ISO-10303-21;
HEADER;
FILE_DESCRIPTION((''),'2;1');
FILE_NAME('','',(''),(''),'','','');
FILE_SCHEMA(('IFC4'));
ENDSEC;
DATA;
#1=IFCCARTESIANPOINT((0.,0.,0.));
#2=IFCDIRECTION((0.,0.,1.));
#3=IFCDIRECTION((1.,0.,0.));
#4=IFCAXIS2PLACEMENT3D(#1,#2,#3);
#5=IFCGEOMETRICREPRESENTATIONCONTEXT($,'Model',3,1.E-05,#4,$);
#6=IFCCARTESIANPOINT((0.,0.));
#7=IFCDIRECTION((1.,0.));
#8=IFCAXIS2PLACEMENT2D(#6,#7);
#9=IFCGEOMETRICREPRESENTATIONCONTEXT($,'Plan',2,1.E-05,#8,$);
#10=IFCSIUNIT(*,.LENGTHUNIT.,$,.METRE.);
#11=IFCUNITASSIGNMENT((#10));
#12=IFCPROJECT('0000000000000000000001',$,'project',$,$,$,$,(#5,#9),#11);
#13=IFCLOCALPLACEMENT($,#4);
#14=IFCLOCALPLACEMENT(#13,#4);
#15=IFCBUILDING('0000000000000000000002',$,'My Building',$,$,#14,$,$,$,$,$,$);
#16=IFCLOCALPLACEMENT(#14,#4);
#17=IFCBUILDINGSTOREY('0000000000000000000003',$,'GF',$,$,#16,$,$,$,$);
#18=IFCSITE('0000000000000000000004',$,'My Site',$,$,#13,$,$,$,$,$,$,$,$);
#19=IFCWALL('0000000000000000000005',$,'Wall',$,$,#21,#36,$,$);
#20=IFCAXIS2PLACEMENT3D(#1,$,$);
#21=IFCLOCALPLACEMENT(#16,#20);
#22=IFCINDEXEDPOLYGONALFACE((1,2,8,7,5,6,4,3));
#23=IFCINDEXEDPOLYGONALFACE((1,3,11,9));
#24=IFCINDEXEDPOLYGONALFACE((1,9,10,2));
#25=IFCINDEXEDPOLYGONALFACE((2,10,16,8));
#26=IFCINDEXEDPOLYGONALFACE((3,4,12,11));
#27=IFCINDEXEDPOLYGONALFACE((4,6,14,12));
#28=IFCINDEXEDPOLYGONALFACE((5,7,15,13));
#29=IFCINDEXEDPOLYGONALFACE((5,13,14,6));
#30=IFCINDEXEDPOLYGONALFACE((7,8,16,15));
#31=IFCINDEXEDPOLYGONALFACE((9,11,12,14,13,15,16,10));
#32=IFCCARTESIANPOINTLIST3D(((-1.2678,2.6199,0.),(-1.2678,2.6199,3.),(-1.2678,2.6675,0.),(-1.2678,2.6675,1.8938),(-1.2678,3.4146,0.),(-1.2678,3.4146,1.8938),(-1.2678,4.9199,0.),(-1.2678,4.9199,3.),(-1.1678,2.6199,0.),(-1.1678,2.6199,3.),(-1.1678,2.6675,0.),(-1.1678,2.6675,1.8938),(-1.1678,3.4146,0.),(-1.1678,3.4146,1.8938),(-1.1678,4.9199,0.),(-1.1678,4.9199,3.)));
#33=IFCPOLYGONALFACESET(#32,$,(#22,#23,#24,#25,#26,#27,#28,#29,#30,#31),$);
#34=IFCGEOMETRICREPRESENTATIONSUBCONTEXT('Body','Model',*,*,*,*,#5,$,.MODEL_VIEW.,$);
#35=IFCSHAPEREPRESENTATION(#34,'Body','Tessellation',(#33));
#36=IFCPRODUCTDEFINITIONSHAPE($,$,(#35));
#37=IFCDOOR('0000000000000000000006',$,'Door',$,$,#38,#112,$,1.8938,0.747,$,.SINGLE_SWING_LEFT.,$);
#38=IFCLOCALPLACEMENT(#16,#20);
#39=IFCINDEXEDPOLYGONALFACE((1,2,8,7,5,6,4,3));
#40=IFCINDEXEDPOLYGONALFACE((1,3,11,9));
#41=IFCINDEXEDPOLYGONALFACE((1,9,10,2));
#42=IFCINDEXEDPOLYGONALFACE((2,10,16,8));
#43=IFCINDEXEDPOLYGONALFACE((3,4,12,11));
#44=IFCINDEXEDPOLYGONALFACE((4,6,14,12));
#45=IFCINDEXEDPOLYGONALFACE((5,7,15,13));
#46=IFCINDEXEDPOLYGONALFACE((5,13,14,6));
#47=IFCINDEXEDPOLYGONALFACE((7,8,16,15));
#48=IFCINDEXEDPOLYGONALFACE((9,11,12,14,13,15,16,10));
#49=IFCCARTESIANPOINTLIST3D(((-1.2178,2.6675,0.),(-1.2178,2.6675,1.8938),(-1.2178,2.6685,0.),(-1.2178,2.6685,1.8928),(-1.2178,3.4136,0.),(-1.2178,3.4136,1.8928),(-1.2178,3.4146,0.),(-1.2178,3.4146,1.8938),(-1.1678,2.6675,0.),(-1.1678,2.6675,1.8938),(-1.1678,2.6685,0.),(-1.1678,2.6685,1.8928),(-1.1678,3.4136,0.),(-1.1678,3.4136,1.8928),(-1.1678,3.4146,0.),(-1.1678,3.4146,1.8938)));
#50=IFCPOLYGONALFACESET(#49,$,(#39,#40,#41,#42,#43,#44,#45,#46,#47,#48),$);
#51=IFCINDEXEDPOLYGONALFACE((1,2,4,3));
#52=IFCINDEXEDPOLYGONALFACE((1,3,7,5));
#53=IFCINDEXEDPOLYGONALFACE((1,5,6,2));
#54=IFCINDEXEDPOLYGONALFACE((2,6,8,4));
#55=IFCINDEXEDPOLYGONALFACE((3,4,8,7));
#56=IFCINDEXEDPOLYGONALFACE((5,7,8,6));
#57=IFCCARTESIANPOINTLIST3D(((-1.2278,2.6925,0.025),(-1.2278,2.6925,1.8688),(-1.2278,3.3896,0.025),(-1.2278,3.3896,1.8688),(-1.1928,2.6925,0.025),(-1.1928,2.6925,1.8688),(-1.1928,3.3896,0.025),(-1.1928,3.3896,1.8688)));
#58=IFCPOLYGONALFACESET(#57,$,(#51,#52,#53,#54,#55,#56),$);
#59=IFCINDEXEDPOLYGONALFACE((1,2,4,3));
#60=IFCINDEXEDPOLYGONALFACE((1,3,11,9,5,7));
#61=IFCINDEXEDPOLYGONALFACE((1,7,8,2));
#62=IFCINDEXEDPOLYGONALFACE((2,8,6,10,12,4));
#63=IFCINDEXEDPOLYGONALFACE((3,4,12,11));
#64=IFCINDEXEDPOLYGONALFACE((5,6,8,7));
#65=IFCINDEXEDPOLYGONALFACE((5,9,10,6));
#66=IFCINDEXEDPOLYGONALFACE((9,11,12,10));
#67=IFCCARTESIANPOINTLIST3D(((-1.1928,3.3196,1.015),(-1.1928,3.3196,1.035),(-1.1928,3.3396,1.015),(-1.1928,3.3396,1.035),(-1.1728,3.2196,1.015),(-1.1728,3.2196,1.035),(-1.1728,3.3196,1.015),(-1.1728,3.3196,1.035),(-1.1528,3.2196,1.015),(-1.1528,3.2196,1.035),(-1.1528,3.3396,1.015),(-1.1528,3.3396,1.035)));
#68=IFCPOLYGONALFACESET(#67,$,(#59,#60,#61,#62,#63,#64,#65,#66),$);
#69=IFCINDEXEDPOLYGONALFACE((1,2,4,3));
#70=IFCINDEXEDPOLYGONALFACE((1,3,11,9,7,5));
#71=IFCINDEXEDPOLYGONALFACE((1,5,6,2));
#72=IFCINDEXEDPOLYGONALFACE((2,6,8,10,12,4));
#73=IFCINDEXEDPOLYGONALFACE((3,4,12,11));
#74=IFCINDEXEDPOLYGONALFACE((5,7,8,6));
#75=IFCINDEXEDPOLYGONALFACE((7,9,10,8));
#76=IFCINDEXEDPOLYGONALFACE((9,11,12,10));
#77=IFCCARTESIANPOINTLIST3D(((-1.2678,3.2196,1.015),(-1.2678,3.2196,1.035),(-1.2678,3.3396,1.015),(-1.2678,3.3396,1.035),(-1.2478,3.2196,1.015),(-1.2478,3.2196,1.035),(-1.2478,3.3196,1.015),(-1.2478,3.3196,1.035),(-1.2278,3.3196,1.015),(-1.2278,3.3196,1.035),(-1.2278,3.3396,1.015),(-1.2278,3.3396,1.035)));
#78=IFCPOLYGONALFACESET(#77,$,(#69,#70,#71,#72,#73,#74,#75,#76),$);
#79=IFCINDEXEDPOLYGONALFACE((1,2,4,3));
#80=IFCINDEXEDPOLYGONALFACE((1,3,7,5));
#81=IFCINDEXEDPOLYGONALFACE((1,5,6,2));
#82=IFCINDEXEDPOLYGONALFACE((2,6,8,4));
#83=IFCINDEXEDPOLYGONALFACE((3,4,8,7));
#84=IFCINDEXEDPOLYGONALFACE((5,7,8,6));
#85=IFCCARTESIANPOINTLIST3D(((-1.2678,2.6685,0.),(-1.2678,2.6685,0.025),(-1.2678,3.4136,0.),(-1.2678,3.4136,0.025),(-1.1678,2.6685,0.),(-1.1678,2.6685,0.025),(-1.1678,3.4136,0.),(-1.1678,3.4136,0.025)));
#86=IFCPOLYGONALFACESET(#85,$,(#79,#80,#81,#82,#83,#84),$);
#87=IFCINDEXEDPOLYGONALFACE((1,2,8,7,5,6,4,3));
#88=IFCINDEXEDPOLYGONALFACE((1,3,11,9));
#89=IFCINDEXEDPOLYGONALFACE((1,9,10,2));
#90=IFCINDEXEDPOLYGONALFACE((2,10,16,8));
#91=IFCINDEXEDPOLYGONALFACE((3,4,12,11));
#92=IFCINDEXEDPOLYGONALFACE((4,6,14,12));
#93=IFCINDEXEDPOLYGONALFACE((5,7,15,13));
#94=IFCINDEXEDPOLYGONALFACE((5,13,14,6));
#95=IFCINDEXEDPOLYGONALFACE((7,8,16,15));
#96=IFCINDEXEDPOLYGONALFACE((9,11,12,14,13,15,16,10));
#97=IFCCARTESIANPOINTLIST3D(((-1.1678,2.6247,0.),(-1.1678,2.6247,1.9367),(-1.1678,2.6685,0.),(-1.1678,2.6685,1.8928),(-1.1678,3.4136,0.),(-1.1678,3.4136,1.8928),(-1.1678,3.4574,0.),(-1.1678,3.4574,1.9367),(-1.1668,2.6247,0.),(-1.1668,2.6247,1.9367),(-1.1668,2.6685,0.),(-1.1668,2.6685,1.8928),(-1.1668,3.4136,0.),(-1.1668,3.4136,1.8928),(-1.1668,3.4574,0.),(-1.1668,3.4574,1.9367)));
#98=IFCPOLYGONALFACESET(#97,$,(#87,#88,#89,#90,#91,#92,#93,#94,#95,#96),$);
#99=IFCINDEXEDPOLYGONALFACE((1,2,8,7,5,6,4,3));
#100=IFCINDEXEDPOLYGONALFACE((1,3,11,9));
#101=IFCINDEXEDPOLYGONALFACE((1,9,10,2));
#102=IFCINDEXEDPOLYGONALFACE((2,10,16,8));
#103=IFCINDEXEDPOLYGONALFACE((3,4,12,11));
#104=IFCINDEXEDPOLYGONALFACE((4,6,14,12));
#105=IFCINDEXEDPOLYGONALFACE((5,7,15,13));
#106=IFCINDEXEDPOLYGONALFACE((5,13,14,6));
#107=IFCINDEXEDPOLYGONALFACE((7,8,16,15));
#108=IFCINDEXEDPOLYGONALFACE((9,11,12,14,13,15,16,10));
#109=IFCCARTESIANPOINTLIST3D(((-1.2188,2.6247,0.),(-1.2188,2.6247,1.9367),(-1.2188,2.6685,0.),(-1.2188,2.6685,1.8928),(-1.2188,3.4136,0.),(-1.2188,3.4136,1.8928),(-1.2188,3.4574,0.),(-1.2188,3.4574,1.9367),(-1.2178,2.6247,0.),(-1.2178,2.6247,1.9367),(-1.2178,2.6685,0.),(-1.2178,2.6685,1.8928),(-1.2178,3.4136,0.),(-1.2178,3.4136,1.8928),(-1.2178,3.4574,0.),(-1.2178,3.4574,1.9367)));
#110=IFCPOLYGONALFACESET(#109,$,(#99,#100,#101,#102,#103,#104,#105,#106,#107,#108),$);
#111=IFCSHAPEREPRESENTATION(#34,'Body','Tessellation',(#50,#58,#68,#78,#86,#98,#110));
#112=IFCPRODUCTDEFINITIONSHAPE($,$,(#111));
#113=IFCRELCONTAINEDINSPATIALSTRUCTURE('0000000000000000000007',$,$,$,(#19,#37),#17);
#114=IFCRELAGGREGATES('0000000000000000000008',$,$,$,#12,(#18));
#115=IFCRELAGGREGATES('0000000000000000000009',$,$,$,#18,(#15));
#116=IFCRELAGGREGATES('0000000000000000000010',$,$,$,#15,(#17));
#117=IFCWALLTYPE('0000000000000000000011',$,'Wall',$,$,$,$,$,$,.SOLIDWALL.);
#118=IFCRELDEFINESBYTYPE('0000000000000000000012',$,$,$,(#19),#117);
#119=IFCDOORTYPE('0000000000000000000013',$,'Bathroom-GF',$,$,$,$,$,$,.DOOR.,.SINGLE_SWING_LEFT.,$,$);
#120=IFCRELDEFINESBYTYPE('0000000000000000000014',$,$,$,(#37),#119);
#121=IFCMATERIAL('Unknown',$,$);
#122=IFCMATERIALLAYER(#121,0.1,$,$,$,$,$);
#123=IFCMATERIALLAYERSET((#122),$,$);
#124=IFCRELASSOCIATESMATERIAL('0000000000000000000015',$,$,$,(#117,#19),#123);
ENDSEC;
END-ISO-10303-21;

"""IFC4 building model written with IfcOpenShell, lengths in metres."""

from ifc_helpers import new_model, entity, si_unit, frame, origin_with_axes, origin_2d_with_axis, place, context, subcontext, project, spatial, line, indexed_curve, outline, extrude, shape, source, transform, mapped, material, layer, layer_set, layer_usage, type_object, type_shapes, element, fill, save


model = new_model("IFC4")

# Units and contexts
model_context = context("Model", 3, precision=1e-05, world=origin_with_axes())
plan_context = context("Plan", 2, precision=1e-05, world=origin_2d_with_axis())
body_context_1 = subcontext(model_context, "Body", "Model", "MODEL_VIEW")
body_context_2 = subcontext(plan_context, "Body", "Plan", "PLAN_VIEW")
ifc_project = project(units=[si_unit("LENGTHUNIT", "METRE")], contexts=[model_context, plan_context])

# Site, building, storey
site_placement = place(None, origin_with_axes())
site = spatial("IfcSite", under=ifc_project, at=site_placement, Name="My Site")
building_placement = place(site_placement, origin_with_axes())
building = spatial("IfcBuilding", under=site, at=building_placement, Name="My Building")
storey_placement = place(building_placement, origin_with_axes())
storey = spatial("IfcBuildingStorey", under=building, at=storey_placement, Name="GF")

# Shared definitions
ifc_material_1 = material(Name="Unknown")

# Shared definitions
ifc_layer_1 = layer(ifc_material_1, 0.1)
ifc_layer_set_1 = layer_set([ifc_layer_1])
wall_type = type_object("IfcWallType", Name="Wall", PredefinedType="SOLIDWALL", material=ifc_layer_set_1)

# Wall, opening, door
ifc_layer_usage_1 = layer_usage(ifc_layer_set_1, "AXIS2", "POSITIVE", 0.0)
wall_1_placement = place(storey_placement, frame((-1.1678, 2.6199, 0.0), z_axis=(0.0, 0.0, 1.0), x_axis=(0.0, 1.0, 0.0)))
wall_1 = element("IfcWall", 1, at=wall_1_placement, inside=storey, type_object=wall_type, material=ifc_layer_usage_1, Name="Wall", context=body_context_1, shape_type="SweptSolid", body=[
    extrude(outline(indexed_curve([(0.0, 0.0), (0.0, 0.1), (2.3, 0.1), (2.3, 0.0)], segments=[line(1, 2, 3, 4, 1)])), origin_with_axes(), (0.0, 0.0, 1.0), 3.0),
])
shared_shape_1 = source(origin_with_axes(), body_context_1, "Body", "SweptSolid", [
    extrude(outline(indexed_curve([(0.0, 0.0), (0.747, 0.0), (0.747, 1.8938), (0.0, 1.8938)], segments=[line(1, 2, 3, 4, 1)])), frame((0.0, -0.6, 0.0), z_axis=(0.0, -1.0, 0.0), x_axis=(1.0, 0.0, 0.0)), (0.0, 0.0, -1.0), 1.2),
])
opening_1_placement = place(wall_1_placement, frame((0.0477, 0.0, 0.0), z_axis=(0.0, 0.0, 1.0), x_axis=(1.0, 0.0, 0.0)))
opening_1 = element("IfcOpeningElement", 2, at=opening_1_placement, cuts=wall_1, PredefinedType="OPENING", context=body_context_1, shape_type="MappedRepresentation", body=[
    mapped(shared_shape_1, transform((0.0, 0.0, 0.0), x_axis=(1.0, 0.0, 0.0), y_axis=(0.0, 1.0, 0.0), z_axis=(0.0, 0.0, 1.0), scale=1.0)),
])
door_type_1 = type_object("IfcDoorType", Name="Bathroom-GF", OperationType="SINGLE_SWING_LEFT", PredefinedType="DOOR")
shared_shape_2 = source(origin_with_axes(), body_context_1, "Body", "SweptSolid", [
    extrude(outline(indexed_curve([(0.0, 0.0), (0.0, 1.8938), (0.747, 1.8938), (0.747, 0.0), (0.746, 0.0), (0.746, 1.8928), (0.001, 1.8928), (0.001, 0.0)], segments=[line(1, 2, 3, 4, 5, 6, 7, 8, 1)])), frame((0.0, 0.0, 0.0), z_axis=(0.0, -1.0, 0.0), x_axis=(1.0, 0.0, 0.0)), (0.0, 0.0, -1.0), 0.05),
    extrude(outline(indexed_curve([(0.0, 0.0), (0.697, 0.0), (0.697, 0.035), (0.0, 0.035)], segments=[line(1, 2, 3, 4, 1)])), frame((0.025, 0.025, 0.025), z_axis=(0.0, 0.0, 1.0), x_axis=(1.0, 0.0, 0.0)), (0.0, 0.0, 1.0), 1.8438),
    extrude(outline(indexed_curve([(0.0, 0.0), (0.0, -0.04), (-0.12, -0.04), (-0.12, -0.02), (-0.02, -0.02), (-0.02, 0.0)], segments=[line(1, 2, 3, 4, 5, 6, 1)])), frame((0.672, 0.025, 1.015), z_axis=(0.0, 0.0, 1.0), x_axis=(1.0, 0.0, 0.0)), (0.0, 0.0, 1.0), 0.02),
    extrude(outline(indexed_curve([(0.0, 0.0), (0.0, 0.04), (-0.12, 0.04), (-0.12, 0.02), (-0.02, 0.02), (-0.02, 0.0)], segments=[line(1, 2, 3, 4, 5, 6, 1)])), frame((0.672, 0.06, 1.015), z_axis=(0.0, 0.0, 1.0), x_axis=(1.0, 0.0, 0.0)), (0.0, 0.0, 1.0), 0.02),
    extrude(outline(indexed_curve([(0.0, 0.0), (0.745, 0.0), (0.745, 0.1), (0.0, 0.1)], segments=[line(1, 2, 3, 4, 1)])), frame((0.001, 0.0, 0.0), z_axis=(0.0, 0.0, 1.0), x_axis=(1.0, 0.0, 0.0)), (0.0, 0.0, 1.0), 0.025),
    extrude(outline(indexed_curve([(0.0, 0.0), (0.0, 1.9367), (0.8327, 1.9367), (0.8327, 0.0), (0.7889, 0.0), (0.7889, 1.8928), (0.0439, 1.8928), (0.0439, 0.0)], segments=[line(1, 2, 3, 4, 5, 6, 7, 8, 1)])), frame((-0.0429, -0.001, 0.0), z_axis=(0.0, -1.0, 0.0), x_axis=(1.0, 0.0, 0.0)), (0.0, 0.0, -1.0), 0.001),
    extrude(outline(indexed_curve([(0.0, 0.0), (0.0, 1.9367), (0.8327, 1.9367), (0.8327, 0.0), (0.7889, 0.0), (0.7889, 1.8928), (0.0439, 1.8928), (0.0439, 0.0)], segments=[line(1, 2, 3, 4, 5, 6, 7, 8, 1)])), frame((-0.0429, 0.05, 0.0), z_axis=(0.0, -1.0, 0.0), x_axis=(1.0, 0.0, 0.0)), (0.0, 0.0, -1.0), 0.001),
])
shared_shape_3 = source(origin_with_axes(), body_context_2, "Body", "Curve2D", [
    entity("IfcIndexedPolyCurve", entity("IfcCartesianPointList2D", [[0.0, 0.0], [0.001, 0.0], [0.001, 0.05], [0.0, 0.05]]), [entity("IfcLineIndex", [1, 2, 3, 4, 1])]),
    entity("IfcIndexedPolyCurve", entity("IfcCartesianPointList2D", [[0.747, 0.0], [0.746, 0.0], [0.746, 0.05], [0.747, 0.05]]), [entity("IfcLineIndex", [1, 2, 3, 4, 1])]),
    entity("IfcTrimmedCurve", entity("IfcEllipse", entity("IfcAxis2Placement2D", entity("IfcCartesianPoint", [0.06, 0.05]), entity("IfcDirection", [1.0, 0.0])), 0.662, 0.697), [entity("IfcCartesianPoint", [0.722, 0.05])], [entity("IfcCartesianPoint", [0.06, 0.747])], True, "CARTESIAN"),
    entity("IfcIndexedPolyCurve", entity("IfcCartesianPointList2D", [[0.025, 0.05], [0.06, 0.05], [0.06, 0.747], [0.025, 0.747]]), [entity("IfcLineIndex", [1, 2, 3, 4, 1])]),
])
type_shapes(door_type_1, [shared_shape_2, shared_shape_3])
door_1_placement = place(opening_1_placement, frame((0.0, 0.0, 0.0), z_axis=(0.0, 0.0, 1.0), x_axis=(1.0, 0.0, 0.0)))
door_1 = element("IfcDoor", 3, at=door_1_placement, inside=storey, type_object=door_type_1, Name="Door", OperationType="SINGLE_SWING_LEFT", OverallHeight=1.8938, OverallWidth=0.747, shapes=[
    shape(body_context_1, "Body", "MappedRepresentation", [mapped(shared_shape_2, transform((0.0, 0.0, 0.0), x_axis=(1.0, 0.0, 0.0), y_axis=(0.0, 1.0, 0.0), z_axis=(0.0, 0.0, 1.0), scale=1.0))]),
    shape(body_context_2, "Body", "MappedRepresentation", [mapped(shared_shape_3, transform((0.0, 0.0, 0.0), x_axis=(1.0, 0.0, 0.0), y_axis=(0.0, 1.0, 0.0), z_axis=(0.0, 0.0, 1.0), scale=1.0))]),
])
fill(opening_1, door_1)

save(model, "model.ifc")
